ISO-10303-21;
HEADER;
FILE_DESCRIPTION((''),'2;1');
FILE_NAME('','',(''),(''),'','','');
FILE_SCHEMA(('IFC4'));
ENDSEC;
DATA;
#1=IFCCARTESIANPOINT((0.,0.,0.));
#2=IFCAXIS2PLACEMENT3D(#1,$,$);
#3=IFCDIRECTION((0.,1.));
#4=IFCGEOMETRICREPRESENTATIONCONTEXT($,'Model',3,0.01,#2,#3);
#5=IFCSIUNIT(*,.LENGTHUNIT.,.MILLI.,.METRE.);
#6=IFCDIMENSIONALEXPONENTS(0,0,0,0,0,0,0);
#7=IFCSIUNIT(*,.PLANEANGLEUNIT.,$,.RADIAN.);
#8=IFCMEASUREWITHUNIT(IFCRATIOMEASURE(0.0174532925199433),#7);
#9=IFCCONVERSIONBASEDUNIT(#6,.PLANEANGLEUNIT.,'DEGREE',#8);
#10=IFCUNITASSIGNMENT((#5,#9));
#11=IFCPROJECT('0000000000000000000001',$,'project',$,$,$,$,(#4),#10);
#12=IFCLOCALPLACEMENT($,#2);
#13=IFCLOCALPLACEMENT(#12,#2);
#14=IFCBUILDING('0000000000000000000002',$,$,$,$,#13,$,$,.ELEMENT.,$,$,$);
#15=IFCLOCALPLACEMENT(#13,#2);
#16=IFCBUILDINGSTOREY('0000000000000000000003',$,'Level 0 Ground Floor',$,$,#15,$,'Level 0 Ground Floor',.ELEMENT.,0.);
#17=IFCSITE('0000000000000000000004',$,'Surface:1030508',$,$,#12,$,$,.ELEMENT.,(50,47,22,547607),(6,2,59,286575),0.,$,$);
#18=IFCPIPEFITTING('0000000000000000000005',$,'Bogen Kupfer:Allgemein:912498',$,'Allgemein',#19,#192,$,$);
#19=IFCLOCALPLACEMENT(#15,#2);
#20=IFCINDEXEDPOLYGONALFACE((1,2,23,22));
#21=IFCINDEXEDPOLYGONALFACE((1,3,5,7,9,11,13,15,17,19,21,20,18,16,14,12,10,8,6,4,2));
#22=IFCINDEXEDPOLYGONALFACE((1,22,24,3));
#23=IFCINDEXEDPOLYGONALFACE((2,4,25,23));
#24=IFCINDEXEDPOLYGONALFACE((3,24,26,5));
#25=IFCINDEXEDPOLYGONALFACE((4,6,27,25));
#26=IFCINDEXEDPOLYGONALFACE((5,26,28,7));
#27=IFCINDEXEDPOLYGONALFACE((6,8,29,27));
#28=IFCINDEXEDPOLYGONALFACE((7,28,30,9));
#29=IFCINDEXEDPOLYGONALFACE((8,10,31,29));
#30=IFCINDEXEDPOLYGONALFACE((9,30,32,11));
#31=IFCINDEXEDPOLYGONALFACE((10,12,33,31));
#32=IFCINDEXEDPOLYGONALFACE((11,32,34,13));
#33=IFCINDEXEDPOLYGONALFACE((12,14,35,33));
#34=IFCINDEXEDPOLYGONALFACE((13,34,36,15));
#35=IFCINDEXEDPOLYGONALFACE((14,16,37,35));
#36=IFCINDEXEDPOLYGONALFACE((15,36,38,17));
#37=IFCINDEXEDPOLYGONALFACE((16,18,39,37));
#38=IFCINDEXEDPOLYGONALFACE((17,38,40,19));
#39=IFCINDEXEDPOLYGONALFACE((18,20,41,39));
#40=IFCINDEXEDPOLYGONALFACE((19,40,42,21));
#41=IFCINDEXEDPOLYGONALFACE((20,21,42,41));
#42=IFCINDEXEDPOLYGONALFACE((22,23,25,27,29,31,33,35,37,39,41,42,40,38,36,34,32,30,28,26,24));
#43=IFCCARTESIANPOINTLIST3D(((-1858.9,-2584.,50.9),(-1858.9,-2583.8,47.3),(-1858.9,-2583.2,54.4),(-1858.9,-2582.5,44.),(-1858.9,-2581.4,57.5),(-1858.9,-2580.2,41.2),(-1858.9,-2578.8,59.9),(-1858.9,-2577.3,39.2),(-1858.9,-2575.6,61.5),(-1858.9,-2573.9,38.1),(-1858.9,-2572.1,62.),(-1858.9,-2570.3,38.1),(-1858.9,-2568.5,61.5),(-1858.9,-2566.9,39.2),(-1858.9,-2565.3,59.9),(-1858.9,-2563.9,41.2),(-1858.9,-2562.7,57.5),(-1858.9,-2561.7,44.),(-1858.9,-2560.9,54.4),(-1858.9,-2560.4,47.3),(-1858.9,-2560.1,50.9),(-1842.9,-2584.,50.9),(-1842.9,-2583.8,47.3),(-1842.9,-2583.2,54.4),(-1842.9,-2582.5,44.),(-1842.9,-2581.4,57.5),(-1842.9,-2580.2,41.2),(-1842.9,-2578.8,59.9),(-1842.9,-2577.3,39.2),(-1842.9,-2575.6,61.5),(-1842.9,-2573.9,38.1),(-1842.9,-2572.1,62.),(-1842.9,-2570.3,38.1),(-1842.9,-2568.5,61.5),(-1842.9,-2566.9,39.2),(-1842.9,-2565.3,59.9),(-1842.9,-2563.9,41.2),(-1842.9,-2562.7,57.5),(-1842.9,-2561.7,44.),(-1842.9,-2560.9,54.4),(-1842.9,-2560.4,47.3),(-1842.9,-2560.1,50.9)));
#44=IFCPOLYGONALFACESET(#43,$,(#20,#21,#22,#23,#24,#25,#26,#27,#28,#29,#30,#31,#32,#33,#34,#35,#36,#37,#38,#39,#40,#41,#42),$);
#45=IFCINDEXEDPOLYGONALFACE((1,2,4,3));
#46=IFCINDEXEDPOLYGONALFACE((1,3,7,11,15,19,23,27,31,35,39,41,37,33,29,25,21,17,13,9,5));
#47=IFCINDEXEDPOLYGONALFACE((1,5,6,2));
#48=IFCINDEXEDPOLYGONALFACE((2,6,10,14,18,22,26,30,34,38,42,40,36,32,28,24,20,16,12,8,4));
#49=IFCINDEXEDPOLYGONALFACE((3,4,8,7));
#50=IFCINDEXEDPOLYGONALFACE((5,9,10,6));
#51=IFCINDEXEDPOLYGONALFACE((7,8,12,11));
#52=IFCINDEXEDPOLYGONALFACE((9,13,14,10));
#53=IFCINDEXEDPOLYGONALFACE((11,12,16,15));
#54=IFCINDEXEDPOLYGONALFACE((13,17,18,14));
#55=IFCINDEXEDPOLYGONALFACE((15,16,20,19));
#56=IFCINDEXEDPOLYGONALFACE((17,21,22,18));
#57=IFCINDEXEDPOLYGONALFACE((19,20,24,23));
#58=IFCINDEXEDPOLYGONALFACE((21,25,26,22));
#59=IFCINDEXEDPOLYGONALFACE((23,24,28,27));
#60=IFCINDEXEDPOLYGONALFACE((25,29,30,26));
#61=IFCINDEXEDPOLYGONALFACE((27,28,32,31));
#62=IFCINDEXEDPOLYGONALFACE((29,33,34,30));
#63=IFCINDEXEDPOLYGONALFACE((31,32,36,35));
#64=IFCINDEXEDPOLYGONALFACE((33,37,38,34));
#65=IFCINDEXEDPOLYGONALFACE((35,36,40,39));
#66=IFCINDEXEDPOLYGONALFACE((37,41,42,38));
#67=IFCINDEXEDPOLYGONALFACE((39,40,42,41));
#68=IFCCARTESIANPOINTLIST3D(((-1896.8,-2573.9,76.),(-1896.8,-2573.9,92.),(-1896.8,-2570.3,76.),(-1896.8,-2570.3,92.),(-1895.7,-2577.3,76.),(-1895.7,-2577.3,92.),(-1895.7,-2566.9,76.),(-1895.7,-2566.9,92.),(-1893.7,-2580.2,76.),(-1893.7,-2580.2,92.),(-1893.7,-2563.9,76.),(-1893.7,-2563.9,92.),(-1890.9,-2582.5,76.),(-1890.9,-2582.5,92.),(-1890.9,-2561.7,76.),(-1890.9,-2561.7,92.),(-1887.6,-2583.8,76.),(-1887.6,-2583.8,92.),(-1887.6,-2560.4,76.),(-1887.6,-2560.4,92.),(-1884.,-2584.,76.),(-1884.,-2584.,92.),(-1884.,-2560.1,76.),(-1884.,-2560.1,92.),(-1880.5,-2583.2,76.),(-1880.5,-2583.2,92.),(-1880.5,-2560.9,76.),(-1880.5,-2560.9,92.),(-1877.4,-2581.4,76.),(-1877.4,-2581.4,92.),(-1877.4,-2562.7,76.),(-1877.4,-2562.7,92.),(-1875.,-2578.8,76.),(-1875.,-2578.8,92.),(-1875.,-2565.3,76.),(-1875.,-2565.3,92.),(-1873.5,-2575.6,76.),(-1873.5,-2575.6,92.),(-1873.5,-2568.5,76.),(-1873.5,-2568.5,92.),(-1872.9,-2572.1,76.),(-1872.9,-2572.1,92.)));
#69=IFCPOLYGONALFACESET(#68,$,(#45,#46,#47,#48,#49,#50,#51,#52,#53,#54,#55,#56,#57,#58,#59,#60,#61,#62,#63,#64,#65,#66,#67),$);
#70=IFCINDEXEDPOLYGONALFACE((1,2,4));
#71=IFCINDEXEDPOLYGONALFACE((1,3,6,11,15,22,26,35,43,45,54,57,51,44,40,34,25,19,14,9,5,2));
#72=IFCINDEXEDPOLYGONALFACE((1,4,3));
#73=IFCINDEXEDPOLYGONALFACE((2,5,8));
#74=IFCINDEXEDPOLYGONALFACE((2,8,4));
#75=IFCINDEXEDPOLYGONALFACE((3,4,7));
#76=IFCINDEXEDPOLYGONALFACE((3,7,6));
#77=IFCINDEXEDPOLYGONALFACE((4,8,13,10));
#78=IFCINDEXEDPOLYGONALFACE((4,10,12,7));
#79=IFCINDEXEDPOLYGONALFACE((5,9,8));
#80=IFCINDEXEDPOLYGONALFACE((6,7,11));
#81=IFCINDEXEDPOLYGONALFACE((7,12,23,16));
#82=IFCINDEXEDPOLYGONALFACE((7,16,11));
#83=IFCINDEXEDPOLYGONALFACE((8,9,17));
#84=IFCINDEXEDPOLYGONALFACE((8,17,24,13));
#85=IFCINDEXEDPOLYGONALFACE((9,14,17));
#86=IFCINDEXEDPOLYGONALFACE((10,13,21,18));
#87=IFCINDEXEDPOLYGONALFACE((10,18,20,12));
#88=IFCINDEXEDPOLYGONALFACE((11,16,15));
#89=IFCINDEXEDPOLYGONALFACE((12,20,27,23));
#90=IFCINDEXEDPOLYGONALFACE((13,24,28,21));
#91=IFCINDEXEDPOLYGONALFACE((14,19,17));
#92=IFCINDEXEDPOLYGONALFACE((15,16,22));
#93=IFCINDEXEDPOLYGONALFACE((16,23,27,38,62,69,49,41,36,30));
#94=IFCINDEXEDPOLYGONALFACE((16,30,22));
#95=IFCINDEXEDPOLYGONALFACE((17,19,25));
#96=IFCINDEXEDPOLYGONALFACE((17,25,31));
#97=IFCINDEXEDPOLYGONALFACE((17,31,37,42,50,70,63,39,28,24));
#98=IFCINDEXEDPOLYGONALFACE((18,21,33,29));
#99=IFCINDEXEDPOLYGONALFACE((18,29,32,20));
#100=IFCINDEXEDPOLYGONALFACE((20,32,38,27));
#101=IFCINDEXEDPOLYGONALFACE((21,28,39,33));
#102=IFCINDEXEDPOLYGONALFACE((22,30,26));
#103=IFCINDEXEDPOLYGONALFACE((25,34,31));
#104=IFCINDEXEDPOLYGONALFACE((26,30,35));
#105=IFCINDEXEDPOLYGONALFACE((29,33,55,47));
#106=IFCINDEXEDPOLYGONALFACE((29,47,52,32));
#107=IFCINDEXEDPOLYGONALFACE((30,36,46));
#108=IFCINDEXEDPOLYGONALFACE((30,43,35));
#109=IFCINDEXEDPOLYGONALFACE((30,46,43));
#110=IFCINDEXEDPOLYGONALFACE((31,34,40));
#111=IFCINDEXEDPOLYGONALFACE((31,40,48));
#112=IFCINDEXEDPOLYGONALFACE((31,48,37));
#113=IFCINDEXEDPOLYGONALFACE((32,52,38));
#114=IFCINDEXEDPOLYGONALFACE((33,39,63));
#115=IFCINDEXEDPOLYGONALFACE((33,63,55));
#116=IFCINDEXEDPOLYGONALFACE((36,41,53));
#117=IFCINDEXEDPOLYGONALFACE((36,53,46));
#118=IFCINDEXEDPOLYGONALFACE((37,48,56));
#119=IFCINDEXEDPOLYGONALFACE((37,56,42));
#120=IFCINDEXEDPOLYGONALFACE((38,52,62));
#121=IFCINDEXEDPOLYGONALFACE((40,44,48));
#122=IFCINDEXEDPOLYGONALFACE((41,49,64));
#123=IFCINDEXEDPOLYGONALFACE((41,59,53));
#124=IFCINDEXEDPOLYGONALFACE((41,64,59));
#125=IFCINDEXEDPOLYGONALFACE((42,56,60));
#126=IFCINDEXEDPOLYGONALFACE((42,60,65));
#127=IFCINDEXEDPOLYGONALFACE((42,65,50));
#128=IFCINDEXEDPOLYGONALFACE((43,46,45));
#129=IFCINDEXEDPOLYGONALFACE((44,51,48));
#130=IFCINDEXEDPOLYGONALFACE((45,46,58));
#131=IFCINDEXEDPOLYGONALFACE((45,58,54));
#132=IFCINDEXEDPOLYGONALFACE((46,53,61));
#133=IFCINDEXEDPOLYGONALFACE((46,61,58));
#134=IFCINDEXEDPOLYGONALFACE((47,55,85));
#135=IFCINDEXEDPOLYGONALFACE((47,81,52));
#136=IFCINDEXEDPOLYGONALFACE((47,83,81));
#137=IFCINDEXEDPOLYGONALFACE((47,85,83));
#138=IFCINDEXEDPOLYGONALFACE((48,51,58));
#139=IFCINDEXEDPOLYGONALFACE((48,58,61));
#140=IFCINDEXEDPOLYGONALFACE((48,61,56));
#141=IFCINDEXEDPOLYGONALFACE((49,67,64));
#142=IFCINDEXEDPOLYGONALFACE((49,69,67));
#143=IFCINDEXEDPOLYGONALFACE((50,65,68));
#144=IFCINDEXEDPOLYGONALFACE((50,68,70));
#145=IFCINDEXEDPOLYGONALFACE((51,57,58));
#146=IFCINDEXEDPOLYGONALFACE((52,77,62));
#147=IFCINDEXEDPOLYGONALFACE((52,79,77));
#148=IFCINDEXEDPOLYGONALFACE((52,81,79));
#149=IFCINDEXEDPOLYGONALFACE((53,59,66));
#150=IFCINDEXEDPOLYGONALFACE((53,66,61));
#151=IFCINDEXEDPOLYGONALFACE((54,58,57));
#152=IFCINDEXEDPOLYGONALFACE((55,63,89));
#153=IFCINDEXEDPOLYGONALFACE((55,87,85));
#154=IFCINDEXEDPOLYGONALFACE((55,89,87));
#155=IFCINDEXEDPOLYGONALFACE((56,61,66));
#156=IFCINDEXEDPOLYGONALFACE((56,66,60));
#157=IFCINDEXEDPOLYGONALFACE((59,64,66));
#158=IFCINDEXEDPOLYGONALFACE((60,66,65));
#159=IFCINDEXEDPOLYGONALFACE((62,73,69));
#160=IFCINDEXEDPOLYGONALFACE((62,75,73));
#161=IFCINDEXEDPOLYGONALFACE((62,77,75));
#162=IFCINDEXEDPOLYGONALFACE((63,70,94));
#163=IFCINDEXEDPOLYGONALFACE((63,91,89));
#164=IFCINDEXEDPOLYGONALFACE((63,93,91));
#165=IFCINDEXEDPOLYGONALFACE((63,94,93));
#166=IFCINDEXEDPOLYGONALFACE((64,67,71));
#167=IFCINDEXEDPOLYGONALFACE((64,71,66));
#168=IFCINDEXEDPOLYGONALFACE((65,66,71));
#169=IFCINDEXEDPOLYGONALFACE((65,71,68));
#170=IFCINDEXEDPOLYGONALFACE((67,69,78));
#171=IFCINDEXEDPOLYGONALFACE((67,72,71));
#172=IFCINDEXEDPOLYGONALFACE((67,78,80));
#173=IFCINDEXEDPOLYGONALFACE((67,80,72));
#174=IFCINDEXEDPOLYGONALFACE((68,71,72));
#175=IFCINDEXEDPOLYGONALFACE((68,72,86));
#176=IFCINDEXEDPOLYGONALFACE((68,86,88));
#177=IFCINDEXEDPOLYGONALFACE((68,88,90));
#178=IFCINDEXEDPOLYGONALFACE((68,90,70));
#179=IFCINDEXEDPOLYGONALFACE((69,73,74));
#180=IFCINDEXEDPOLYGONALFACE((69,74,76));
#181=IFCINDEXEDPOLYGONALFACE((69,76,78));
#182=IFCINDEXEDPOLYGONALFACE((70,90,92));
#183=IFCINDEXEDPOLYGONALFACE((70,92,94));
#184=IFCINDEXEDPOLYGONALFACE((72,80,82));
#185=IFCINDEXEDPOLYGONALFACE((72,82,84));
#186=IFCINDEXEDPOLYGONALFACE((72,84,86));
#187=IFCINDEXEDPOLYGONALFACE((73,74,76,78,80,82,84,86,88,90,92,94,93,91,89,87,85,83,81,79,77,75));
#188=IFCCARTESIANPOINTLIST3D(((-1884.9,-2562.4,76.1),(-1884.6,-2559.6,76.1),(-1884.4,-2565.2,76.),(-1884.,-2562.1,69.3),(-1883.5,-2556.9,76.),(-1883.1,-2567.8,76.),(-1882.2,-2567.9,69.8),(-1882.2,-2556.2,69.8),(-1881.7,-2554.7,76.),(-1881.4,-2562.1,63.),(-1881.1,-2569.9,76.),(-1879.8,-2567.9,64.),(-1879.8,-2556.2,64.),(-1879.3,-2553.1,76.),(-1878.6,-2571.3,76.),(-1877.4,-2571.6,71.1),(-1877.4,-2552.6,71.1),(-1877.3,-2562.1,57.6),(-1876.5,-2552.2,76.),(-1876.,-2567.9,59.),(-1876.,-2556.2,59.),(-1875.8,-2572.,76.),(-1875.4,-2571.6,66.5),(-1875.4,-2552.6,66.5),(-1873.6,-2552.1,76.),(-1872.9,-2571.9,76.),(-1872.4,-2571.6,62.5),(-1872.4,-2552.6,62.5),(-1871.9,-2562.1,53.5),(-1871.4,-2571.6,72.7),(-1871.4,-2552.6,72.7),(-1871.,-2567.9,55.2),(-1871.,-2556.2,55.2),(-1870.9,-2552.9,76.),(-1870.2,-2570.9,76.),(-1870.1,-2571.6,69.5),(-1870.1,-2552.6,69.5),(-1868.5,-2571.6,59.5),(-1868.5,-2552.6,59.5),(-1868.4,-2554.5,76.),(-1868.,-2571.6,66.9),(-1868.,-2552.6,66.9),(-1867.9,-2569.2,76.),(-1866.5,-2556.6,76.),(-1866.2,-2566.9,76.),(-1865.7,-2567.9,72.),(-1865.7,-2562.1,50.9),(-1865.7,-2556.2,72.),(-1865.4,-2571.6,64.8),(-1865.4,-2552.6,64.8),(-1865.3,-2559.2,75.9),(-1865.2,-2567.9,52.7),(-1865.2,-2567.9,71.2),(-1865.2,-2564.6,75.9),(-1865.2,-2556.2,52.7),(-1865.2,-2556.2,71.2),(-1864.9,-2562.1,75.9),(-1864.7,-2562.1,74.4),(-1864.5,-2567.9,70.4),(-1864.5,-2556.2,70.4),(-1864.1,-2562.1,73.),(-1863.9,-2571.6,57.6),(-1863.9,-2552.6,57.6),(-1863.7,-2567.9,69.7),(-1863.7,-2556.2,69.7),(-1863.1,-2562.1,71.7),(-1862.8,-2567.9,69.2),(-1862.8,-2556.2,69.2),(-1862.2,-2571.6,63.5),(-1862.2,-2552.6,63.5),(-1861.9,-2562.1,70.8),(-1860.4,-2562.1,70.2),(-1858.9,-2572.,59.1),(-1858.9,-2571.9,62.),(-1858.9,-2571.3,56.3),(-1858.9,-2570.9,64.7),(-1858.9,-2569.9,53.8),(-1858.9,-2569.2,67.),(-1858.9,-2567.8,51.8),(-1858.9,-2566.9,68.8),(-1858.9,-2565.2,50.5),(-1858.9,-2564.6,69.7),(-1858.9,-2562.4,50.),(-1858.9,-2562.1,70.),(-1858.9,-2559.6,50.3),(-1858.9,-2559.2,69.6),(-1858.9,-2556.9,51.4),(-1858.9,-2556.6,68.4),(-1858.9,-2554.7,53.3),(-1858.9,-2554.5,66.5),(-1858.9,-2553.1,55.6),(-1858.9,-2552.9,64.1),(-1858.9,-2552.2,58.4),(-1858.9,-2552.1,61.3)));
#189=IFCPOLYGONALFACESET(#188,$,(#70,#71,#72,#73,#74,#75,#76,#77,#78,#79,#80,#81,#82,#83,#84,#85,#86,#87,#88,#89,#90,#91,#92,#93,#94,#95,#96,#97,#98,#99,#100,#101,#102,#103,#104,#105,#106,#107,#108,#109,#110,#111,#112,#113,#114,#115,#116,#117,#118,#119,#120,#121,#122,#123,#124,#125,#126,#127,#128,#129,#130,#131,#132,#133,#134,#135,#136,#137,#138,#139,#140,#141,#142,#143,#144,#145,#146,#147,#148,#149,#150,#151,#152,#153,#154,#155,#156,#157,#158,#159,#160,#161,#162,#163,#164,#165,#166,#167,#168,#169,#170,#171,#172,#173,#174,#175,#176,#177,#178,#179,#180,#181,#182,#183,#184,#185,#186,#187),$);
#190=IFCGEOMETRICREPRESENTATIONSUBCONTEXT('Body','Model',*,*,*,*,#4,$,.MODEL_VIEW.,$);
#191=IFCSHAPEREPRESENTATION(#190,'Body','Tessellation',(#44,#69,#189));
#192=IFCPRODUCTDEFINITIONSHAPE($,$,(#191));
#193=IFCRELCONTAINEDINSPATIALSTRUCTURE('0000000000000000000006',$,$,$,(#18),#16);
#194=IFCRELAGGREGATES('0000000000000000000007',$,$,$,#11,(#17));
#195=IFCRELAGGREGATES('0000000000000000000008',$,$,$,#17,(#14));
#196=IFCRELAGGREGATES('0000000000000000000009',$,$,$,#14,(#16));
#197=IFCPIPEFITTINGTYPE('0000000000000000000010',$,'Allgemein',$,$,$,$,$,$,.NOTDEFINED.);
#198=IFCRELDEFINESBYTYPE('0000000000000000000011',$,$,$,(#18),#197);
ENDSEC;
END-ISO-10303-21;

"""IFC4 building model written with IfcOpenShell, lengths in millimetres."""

from ifc_helpers import new_model, entity, si_unit, converted_unit, direction, frame, frame_2d, origin, place, context, subcontext, project, spatial, circle, extrude, source, transform, mapped, type_object, type_shapes, element, save


model = new_model("IFC4")

# Units and contexts
model_context = context("Model", 3, precision=0.01, world=origin(), true_north=direction((0.0, 1.0)))
body_context = subcontext(model_context, "Body", "Model", "MODEL_VIEW")
ifc_project = project(units=[si_unit("LENGTHUNIT", "METRE", prefix="MILLI"), converted_unit("PLANEANGLEUNIT", "DEGREE", entity("IfcRatioMeasure", 0.0174532925199433), si_unit("PLANEANGLEUNIT", "RADIAN"), dimensions=[0, 0, 0, 0, 0, 0, 0])], contexts=[model_context])

# Site, building, storey
site_placement = place(None, origin())
site = spatial("IfcSite", under=ifc_project, at=site_placement, Name="Surface:1030508", CompositionType="ELEMENT", RefLatitude=(50, 47, 22, 547607), RefLongitude=(6, 2, 59, 286575), RefElevation=0.0)
building_placement = place(site_placement, origin())
building = spatial("IfcBuilding", under=site, at=building_placement, CompositionType="ELEMENT")
storey_placement = place(building_placement, origin())
storey = spatial("IfcBuildingStorey", under=building, at=storey_placement, Name="Level 0 Ground Floor", LongName="Level 0 Ground Floor", CompositionType="ELEMENT", Elevation=0.0)

# Pipe fitting
pipe_fitting_type_1 = type_object("IfcPipeFittingType", Name="Allgemein", PredefinedType="NOTDEFINED")
ifc_direction_1 = entity("IfcDirection", [0.0, 0.0, -1.0])
trimmed_curve_1 = entity("IfcTrimmedCurve", entity("IfcCircle", entity("IfcAxis2Placement2D", entity("IfcCartesianPoint", [-16.0, 0.0]), entity("IfcDirection", [0.0, 1.0])), 16.0), [entity("IfcParameterValue", 270.0)], [entity("IfcParameterValue", 0.0)], True, "PARAMETER")
shared_shape_1 = source(origin(), body_context, "Body", "SolidModel", [
    extrude(circle(Radius=12.0, at=frame_2d((0.0, 0.0), x_axis=(1.0, 0.0))), frame((0.0, 26.0, 0.0), z_axis=(0.0, 1.0, 0.0), x_axis=(-1.0, 0.0, 0.0)), (0.0, 0.0, 1.0), 16.0),
    extrude(circle(Radius=12.0, at=frame_2d((0.0, 0.0), x_axis=(1.0, 0.0))), frame((-42.0, 0.0, 0.0), z_axis=(1.0, 0.0, 0.0), x_axis=(0.0, 1.0, 0.0)), (0.0, 0.0, 1.0), 16.0),
    entity("IfcSurfaceCurveSweptAreaSolid", entity("IfcCircleProfileDef", "AREA", None, entity("IfcAxis2Placement2D", entity("IfcCartesianPoint", [0.0, 10.0]), entity("IfcDirection", [1.0, 0.0])), 10.0), entity("IfcAxis2Placement3D", entity("IfcCartesianPoint", [-10.0, 26.0, 0.0]), ifc_direction_1, entity("IfcDirection", [1.0, 0.0, 0.0])), trimmed_curve_1, 0.0, 90.0, entity("IfcSurfaceOfLinearExtrusion", entity("IfcArbitraryOpenProfileDef", "CURVE", None, trimmed_curve_1), entity("IfcAxis2Placement3D", entity("IfcCartesianPoint", [0.0, 0.0, -304.8])), ifc_direction_1, 1.0)),
])
type_shapes(pipe_fitting_type_1, [shared_shape_1])
for number, where, z_axis, x_axis, name in (
    (1, (-1884.9, -2572.1, 50.0), (0.000001, -1.0, 0.0), (0.0, 0.0, -1.0), "Bogen Kupfer:Allgemein:912498"),
):
    element("IfcPipeFitting", number, at=place(storey_placement, frame(where, z_axis=z_axis, x_axis=x_axis)), inside=storey, type_object=pipe_fitting_type_1, Name=name, ObjectType="Allgemein", context=body_context, shape_type="MappedRepresentation", body=[
        mapped(shared_shape_1, transform((0.0, 0.0, 0.0), scale=1.0)),
    ])

save(model, "model.ifc")
